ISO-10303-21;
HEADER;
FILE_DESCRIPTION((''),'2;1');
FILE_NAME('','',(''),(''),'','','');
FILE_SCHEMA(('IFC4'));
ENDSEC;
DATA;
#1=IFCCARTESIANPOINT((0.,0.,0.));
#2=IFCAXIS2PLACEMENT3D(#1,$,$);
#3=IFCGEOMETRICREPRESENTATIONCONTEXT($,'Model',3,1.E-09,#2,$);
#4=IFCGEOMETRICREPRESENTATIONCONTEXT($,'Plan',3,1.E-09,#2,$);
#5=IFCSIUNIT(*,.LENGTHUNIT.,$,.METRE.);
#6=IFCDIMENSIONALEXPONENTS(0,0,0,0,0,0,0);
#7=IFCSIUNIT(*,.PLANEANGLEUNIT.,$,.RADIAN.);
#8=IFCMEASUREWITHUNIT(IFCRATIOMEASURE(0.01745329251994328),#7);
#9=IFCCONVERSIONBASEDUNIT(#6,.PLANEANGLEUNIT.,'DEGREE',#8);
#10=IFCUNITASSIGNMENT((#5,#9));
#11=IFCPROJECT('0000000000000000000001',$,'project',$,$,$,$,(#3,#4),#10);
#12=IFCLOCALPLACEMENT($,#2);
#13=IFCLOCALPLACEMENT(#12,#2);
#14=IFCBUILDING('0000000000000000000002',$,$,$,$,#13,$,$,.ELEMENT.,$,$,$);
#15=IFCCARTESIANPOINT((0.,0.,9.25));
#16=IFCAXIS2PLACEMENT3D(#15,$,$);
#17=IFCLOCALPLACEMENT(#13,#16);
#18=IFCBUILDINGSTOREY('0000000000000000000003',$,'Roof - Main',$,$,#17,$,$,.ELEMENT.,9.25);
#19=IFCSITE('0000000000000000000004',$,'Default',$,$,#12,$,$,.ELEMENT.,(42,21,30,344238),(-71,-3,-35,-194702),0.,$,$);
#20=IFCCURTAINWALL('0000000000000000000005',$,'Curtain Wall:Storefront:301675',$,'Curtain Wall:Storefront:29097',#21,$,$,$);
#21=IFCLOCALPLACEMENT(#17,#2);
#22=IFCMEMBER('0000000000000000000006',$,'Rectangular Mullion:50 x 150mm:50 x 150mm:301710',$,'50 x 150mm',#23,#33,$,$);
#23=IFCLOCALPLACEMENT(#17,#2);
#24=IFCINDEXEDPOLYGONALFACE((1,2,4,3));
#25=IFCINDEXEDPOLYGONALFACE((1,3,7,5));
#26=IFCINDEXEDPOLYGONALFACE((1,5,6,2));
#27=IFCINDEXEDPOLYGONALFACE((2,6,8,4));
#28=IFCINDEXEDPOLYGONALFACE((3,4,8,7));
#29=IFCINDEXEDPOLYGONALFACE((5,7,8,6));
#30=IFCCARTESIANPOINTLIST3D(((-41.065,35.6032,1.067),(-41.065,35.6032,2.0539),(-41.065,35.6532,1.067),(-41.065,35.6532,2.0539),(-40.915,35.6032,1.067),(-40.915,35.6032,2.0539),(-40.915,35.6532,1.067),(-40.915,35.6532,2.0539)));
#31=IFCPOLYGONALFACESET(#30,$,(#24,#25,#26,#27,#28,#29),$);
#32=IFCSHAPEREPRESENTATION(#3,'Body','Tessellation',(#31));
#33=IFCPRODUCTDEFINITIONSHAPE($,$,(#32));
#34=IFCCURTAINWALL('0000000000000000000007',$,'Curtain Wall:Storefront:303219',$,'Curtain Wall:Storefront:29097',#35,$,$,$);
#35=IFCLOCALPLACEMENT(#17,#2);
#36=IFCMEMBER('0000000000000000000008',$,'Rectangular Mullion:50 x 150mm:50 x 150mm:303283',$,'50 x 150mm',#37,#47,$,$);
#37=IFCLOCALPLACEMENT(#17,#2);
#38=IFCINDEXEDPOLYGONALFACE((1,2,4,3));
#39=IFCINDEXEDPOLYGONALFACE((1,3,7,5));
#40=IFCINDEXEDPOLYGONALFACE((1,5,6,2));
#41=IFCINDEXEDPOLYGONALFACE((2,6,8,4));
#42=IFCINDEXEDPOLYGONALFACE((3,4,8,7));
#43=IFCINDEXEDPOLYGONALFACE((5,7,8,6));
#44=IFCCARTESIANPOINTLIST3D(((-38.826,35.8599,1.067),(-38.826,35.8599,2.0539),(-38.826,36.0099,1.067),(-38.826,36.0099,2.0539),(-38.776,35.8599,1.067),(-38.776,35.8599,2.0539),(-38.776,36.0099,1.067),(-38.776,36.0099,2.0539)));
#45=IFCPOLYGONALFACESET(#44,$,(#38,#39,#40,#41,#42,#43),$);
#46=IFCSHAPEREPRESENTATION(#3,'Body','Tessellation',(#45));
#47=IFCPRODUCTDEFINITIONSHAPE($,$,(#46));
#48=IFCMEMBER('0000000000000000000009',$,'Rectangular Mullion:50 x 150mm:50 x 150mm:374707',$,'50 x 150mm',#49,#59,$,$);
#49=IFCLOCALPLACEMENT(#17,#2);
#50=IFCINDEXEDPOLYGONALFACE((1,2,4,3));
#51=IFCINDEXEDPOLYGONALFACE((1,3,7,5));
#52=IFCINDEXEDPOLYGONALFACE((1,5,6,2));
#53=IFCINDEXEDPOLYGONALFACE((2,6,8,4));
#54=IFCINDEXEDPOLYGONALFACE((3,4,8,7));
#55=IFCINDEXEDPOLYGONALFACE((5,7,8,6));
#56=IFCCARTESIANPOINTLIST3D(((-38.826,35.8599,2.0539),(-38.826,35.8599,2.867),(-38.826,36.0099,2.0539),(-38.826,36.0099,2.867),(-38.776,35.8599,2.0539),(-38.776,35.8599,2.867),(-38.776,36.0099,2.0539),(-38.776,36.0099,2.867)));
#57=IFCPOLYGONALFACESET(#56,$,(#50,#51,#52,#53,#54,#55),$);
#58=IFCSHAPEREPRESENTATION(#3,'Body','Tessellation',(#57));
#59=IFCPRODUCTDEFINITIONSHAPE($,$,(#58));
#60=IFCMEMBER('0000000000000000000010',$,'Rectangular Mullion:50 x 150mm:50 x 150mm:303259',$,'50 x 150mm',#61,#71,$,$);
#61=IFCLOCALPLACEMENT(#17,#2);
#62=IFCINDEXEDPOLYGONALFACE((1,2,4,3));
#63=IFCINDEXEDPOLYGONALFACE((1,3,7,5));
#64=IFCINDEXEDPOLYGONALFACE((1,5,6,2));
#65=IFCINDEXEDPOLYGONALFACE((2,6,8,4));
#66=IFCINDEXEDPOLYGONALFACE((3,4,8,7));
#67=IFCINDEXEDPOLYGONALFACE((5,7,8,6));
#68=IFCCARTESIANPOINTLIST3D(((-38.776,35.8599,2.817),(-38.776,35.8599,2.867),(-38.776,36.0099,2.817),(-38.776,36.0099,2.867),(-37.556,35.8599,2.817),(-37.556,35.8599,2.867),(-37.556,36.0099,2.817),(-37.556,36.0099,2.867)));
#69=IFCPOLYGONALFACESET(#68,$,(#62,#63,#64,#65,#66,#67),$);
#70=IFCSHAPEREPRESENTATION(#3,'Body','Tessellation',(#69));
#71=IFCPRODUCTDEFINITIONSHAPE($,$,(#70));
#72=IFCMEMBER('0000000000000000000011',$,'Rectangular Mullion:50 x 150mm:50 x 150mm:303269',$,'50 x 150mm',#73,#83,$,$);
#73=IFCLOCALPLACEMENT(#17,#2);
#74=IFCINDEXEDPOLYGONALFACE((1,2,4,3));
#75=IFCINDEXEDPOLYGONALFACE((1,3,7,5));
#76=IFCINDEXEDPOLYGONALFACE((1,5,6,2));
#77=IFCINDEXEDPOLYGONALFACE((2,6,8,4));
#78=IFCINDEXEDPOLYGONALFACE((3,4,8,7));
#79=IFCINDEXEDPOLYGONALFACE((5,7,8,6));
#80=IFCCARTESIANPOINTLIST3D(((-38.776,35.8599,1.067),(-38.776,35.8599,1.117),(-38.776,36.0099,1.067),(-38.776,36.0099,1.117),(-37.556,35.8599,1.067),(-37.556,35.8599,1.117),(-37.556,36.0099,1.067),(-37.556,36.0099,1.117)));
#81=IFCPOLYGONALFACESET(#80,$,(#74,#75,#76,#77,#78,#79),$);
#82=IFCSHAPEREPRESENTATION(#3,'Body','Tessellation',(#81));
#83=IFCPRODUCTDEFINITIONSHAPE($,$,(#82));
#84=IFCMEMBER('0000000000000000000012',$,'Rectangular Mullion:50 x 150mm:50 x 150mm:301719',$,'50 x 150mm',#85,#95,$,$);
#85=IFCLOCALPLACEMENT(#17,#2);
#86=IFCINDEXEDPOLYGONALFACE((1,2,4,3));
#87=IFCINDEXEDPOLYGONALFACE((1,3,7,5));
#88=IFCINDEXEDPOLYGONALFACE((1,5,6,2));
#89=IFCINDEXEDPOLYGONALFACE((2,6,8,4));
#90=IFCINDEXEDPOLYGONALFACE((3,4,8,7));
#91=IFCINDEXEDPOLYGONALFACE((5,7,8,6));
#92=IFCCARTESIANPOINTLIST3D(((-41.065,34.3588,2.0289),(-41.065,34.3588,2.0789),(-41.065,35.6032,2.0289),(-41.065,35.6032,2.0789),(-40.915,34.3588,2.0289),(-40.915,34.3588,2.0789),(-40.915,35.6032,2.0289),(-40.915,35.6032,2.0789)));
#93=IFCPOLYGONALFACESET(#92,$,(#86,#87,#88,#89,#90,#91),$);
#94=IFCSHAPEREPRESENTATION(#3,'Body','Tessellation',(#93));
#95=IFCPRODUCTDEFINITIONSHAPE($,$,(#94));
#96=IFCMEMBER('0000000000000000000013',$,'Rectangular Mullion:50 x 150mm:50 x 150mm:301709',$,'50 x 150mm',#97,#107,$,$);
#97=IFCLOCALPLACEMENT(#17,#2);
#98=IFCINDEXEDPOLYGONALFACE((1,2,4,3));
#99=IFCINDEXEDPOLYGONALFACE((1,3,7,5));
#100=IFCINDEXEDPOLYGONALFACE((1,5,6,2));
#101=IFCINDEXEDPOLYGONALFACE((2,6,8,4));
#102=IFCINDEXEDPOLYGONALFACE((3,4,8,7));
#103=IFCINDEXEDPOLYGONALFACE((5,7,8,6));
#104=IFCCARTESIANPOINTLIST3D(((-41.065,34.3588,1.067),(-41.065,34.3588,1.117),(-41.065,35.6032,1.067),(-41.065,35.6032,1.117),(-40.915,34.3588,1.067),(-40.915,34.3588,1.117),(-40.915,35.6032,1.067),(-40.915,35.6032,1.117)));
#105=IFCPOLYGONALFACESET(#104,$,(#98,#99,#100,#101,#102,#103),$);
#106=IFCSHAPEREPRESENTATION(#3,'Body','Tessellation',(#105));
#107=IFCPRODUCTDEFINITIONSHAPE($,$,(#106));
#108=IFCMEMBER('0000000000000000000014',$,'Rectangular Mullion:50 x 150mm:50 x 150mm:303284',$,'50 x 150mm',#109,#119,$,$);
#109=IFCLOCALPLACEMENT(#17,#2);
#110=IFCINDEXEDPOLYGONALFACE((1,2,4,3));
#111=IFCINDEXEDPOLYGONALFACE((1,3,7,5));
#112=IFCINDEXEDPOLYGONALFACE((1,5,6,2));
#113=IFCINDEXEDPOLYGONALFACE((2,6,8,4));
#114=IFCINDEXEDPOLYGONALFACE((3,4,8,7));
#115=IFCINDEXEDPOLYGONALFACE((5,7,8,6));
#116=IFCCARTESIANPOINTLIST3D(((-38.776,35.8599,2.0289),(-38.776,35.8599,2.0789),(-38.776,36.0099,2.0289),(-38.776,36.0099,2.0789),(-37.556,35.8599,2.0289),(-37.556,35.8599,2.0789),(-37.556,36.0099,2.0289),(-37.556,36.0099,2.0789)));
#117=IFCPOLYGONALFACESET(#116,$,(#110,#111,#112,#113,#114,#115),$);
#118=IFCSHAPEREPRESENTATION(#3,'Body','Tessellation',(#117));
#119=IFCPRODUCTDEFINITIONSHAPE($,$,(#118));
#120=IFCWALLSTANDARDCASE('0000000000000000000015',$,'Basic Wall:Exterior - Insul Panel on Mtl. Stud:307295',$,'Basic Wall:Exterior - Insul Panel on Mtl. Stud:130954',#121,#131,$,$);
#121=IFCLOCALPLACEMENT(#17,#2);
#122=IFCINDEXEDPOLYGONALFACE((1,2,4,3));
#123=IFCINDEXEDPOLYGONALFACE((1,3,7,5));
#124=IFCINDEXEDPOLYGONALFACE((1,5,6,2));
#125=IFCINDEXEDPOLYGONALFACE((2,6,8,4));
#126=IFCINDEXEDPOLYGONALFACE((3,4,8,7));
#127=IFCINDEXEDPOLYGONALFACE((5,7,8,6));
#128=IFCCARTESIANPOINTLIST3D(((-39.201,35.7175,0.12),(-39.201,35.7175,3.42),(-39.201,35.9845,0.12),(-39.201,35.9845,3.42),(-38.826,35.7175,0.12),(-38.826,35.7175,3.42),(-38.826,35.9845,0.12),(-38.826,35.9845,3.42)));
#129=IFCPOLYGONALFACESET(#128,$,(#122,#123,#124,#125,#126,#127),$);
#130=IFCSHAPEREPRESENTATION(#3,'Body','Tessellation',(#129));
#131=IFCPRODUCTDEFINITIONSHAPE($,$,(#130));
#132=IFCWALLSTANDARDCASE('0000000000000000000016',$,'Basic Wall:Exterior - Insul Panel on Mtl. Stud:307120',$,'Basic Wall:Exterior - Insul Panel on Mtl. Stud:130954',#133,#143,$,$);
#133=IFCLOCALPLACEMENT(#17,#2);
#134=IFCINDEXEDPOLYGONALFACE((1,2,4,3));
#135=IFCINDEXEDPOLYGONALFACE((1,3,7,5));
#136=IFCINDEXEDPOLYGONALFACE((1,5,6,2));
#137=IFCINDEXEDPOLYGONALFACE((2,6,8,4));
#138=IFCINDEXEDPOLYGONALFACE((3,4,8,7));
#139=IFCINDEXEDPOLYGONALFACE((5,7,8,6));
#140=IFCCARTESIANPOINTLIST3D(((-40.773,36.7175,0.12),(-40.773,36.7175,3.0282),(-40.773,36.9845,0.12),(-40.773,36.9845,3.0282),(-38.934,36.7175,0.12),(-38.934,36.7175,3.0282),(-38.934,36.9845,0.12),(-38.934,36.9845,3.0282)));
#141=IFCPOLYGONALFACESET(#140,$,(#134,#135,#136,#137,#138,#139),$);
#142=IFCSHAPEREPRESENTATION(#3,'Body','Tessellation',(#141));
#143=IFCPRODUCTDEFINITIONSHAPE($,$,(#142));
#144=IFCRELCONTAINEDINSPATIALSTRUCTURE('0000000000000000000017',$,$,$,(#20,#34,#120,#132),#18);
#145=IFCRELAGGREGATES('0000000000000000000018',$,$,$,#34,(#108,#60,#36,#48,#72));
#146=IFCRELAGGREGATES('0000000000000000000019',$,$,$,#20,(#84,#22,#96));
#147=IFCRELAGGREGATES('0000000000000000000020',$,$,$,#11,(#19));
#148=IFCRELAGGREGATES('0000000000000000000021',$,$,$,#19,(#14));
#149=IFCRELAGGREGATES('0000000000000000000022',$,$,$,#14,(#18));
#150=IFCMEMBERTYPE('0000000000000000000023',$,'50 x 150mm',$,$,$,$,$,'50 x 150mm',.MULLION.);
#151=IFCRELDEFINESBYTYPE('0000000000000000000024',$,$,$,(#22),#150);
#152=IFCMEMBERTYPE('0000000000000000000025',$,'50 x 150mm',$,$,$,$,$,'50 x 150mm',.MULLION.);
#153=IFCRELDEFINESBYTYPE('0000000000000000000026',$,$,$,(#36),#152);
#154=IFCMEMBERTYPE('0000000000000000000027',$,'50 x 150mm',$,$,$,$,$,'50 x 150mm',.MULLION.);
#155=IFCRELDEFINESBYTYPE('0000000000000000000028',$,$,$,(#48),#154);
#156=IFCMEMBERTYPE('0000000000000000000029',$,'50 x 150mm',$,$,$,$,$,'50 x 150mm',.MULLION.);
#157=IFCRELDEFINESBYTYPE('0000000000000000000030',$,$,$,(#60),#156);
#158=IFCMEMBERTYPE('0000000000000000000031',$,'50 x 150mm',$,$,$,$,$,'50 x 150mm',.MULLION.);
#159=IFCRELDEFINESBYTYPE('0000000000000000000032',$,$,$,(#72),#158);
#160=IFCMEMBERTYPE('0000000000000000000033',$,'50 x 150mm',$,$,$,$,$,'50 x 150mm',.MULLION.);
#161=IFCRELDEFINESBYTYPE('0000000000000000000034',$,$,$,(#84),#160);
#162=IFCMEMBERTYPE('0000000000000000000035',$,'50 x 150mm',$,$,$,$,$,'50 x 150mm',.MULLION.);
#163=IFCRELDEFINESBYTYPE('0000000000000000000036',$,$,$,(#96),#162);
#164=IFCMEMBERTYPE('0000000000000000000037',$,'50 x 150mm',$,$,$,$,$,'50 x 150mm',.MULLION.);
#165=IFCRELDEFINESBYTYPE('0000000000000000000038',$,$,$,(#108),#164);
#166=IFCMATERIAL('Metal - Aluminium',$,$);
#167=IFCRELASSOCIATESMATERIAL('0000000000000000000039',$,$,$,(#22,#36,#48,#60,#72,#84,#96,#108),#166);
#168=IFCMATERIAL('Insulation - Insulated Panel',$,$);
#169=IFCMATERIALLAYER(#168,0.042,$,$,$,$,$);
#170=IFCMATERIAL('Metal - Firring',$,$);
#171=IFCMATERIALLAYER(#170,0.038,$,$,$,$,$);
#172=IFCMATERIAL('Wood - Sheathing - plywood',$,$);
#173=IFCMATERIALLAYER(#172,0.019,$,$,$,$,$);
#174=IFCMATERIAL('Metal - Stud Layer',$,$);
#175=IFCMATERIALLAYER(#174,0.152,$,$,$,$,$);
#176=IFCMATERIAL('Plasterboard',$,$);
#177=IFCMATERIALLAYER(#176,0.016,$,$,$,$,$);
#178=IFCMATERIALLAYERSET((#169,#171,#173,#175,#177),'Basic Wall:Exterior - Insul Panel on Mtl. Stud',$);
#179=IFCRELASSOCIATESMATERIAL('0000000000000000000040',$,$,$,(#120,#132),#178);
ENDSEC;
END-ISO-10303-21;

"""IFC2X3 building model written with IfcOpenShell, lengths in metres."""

from ifc_helpers import new_model, entity, si_unit, converted_unit, frame, frame_2d, origin, origin_2d_with_axis, place, context, project, spatial, rectangle, extrude, source, transform, mapped, material, layer, layer_set, layer_usage, type_object, type_shapes, element, aggregate, save


model = new_model("IFC2X3")

# Units and contexts
model_context = context("Model", 3, precision=1e-09, world=origin())
plan_context = context("Plan", 3, precision=1e-09, world=origin())
ifc_project = project(units=[si_unit("LENGTHUNIT", "METRE"), converted_unit("PLANEANGLEUNIT", "DEGREE", entity("IfcRatioMeasure", 0.01745329251994328), si_unit("PLANEANGLEUNIT", "RADIAN"), dimensions=[0, 0, 0, 0, 0, 0, 0])], contexts=[model_context, plan_context])

# Site, building, storey
site_placement = place(None, origin())
site = spatial("IfcSite", under=ifc_project, at=site_placement, Name="Default", CompositionType="ELEMENT", RefLatitude=(42, 21, 30, 344238), RefLongitude=(-71, -3, -35, -194702), RefElevation=0.0)
building_placement = place(site_placement, origin())
building = spatial("IfcBuilding", under=site, at=building_placement, CompositionType="ELEMENT")
storey_placement = place(building_placement, frame((0.0, 0.0, 9.25)))
storey = spatial("IfcBuildingStorey", under=building, at=storey_placement, Name="Roof - Main", CompositionType="ELEMENT", Elevation=9.25)

# Curtain wall, member
curtain_wall_1_placement = place(storey_placement, origin())
curtain_wall_1 = element("IfcCurtainWall", 1, at=curtain_wall_1_placement, inside=storey, Name="Curtain Wall:Storefront:301675", ObjectType="Curtain Wall:Storefront:29097")
ifc_material_1 = material(Name="Metal - Aluminium")
member_type_1 = type_object("IfcMemberType", Name="50 x 150mm", ElementType="50 x 150mm", PredefinedType="MULLION")
shared_shape_1 = source(origin(), model_context, "Body", "SweptSolid", [
    extrude(rectangle(XDim=0.05, YDim=0.15, at=origin_2d_with_axis()), frame((-0.025, 0.0, -0.9869), z_axis=(0.0, 0.0, 1.0), x_axis=(-1.0, 0.0, 0.0)), (0.0, 0.0, 1.0), 0.9869),
])
type_shapes(member_type_1, [shared_shape_1])
member_1_placement = place(storey_placement, frame((-40.99, 35.6532, 1.067), z_axis=(0.0, 0.0, -1.0), x_axis=(0.0, 1.0, 0.0)))
member_1 = element("IfcMember", 2, at=member_1_placement, type_object=member_type_1, material=ifc_material_1, Name="Rectangular Mullion:50 x 150mm:50 x 150mm:301710", ObjectType="50 x 150mm", context=model_context, shape_type="MappedRepresentation", body=[
    mapped(shared_shape_1, transform((0.0, 0.0, 0.0), scale=1.0)),
])

# Curtain wall, members
curtain_wall_2_placement = place(storey_placement, origin())
curtain_wall_2 = element("IfcCurtainWall", 3, at=curtain_wall_2_placement, inside=storey, Name="Curtain Wall:Storefront:303219", ObjectType="Curtain Wall:Storefront:29097")
member_type_2 = type_object("IfcMemberType", Name="50 x 150mm", ElementType="50 x 150mm", PredefinedType="MULLION")
shared_shape_2 = source(origin(), model_context, "Body", "SweptSolid", [
    extrude(rectangle(XDim=0.05, YDim=0.15, at=origin_2d_with_axis()), frame((-0.025, 0.0, -0.9869), z_axis=(0.0, 0.0, 1.0), x_axis=(-1.0, 0.0, 0.0)), (0.0, 0.0, 1.0), 0.9869),
])
type_shapes(member_type_2, [shared_shape_2])
member_2_placement = place(storey_placement, frame((-38.826, 35.9349, 2.0539), z_axis=(0.0, 0.0, 1.0), x_axis=(-1.0, 0.0, 0.0)))
member_2 = element("IfcMember", 4, at=member_2_placement, type_object=member_type_2, material=ifc_material_1, Name="Rectangular Mullion:50 x 150mm:50 x 150mm:303283", ObjectType="50 x 150mm", context=model_context, shape_type="MappedRepresentation", body=[
    mapped(shared_shape_2, transform((0.0, 0.0, 0.0), scale=1.0)),
])
member_type_3 = type_object("IfcMemberType", Name="50 x 150mm", ElementType="50 x 150mm", PredefinedType="MULLION")
shared_shape_3 = source(origin(), model_context, "Body", "SweptSolid", [
    extrude(rectangle(XDim=0.05, YDim=0.15, at=origin_2d_with_axis()), frame((-0.025, 0.0, -0.8131), z_axis=(0.0, 0.0, 1.0), x_axis=(-1.0, 0.0, 0.0)), (0.0, 0.0, 1.0), 0.8131),
])
type_shapes(member_type_3, [shared_shape_3])
member_3_placement = place(storey_placement, frame((-38.826, 35.9349, 2.867), z_axis=(0.0, 0.0, 1.0), x_axis=(-1.0, 0.0, 0.0)))
member_3 = element("IfcMember", 5, at=member_3_placement, type_object=member_type_3, material=ifc_material_1, Name="Rectangular Mullion:50 x 150mm:50 x 150mm:374707", ObjectType="50 x 150mm", context=model_context, shape_type="MappedRepresentation", body=[
    mapped(shared_shape_3, transform((0.0, 0.0, 0.0), scale=1.0)),
])
member_type_4 = type_object("IfcMemberType", Name="50 x 150mm", ElementType="50 x 150mm", PredefinedType="MULLION")
shared_shape_4 = source(origin(), model_context, "Body", "SweptSolid", [
    extrude(rectangle(XDim=0.05, YDim=0.15, at=origin_2d_with_axis()), frame((-0.025, 0.0, -1.22), z_axis=(0.0, 0.0, 1.0), x_axis=(-1.0, 0.0, 0.0)), (0.0, 0.0, 1.0), 1.22),
])
type_shapes(member_type_4, [shared_shape_4])
member_4_placement = place(storey_placement, frame((-37.556, 35.9349, 2.867), z_axis=(1.0, 0.0, 0.0), x_axis=(0.0, 0.0, 1.0)))
member_4 = element("IfcMember", 6, at=member_4_placement, type_object=member_type_4, material=ifc_material_1, Name="Rectangular Mullion:50 x 150mm:50 x 150mm:303259", ObjectType="50 x 150mm", context=model_context, shape_type="MappedRepresentation", body=[
    mapped(shared_shape_4, transform((0.0, 0.0, 0.0), scale=1.0)),
])
member_type_5 = type_object("IfcMemberType", Name="50 x 150mm", ElementType="50 x 150mm", PredefinedType="MULLION")
type_shapes(member_type_5, [shared_shape_4])
member_5_placement = place(storey_placement, frame((-38.776, 35.9349, 1.067), z_axis=(-1.0, 0.0, 0.0), x_axis=(0.0, 0.0, -1.0)))
member_5 = element("IfcMember", 7, at=member_5_placement, type_object=member_type_5, material=ifc_material_1, Name="Rectangular Mullion:50 x 150mm:50 x 150mm:303269", ObjectType="50 x 150mm", context=model_context, shape_type="MappedRepresentation", body=[
    mapped(shared_shape_4, transform((0.0, 0.0, 0.0), scale=1.0)),
])

# Members
member_type_6 = type_object("IfcMemberType", Name="50 x 150mm", ElementType="50 x 150mm", PredefinedType="MULLION")
shared_shape_5 = source(origin(), model_context, "Body", "SweptSolid", [
    extrude(rectangle(XDim=0.05, YDim=0.15, at=origin_2d_with_axis()), frame((0.0, 0.0, -1.2444), z_axis=(0.0, 0.0, 1.0), x_axis=(-1.0, 0.0, 0.0)), (0.0, 0.0, 1.0), 1.2444),
])
type_shapes(member_type_6, [shared_shape_5])
member_6_placement = place(storey_placement, frame((-40.99, 35.6032, 2.0539), z_axis=(0.0, 1.0, 0.0), x_axis=(0.0, 0.0, 1.0)))
member_6 = element("IfcMember", 8, at=member_6_placement, type_object=member_type_6, material=ifc_material_1, Name="Rectangular Mullion:50 x 150mm:50 x 150mm:301719", ObjectType="50 x 150mm", context=model_context, shape_type="MappedRepresentation", body=[
    mapped(shared_shape_5, transform((0.0, 0.0, 0.0), scale=1.0)),
])
member_type_7 = type_object("IfcMemberType", Name="50 x 150mm", ElementType="50 x 150mm", PredefinedType="MULLION")
shared_shape_6 = source(origin(), model_context, "Body", "SweptSolid", [
    extrude(rectangle(XDim=0.05, YDim=0.15, at=origin_2d_with_axis()), frame((-0.025, 0.0, -1.2444), z_axis=(0.0, 0.0, 1.0), x_axis=(-1.0, 0.0, 0.0)), (0.0, 0.0, 1.0), 1.2444),
])
type_shapes(member_type_7, [shared_shape_6])
member_7_placement = place(storey_placement, frame((-40.99, 34.3588, 1.067), z_axis=(0.0, -1.0, 0.0), x_axis=(0.0, 0.0, -1.0)))
member_7 = element("IfcMember", 9, at=member_7_placement, type_object=member_type_7, material=ifc_material_1, Name="Rectangular Mullion:50 x 150mm:50 x 150mm:301709", ObjectType="50 x 150mm", context=model_context, shape_type="MappedRepresentation", body=[
    mapped(shared_shape_6, transform((0.0, 0.0, 0.0), scale=1.0)),
])
member_type_8 = type_object("IfcMemberType", Name="50 x 150mm", ElementType="50 x 150mm", PredefinedType="MULLION")
shared_shape_7 = source(origin(), model_context, "Body", "SweptSolid", [
    extrude(rectangle(XDim=0.05, YDim=0.15, at=origin_2d_with_axis()), frame((0.0, 0.0, -1.22), z_axis=(0.0, 0.0, 1.0), x_axis=(-1.0, 0.0, 0.0)), (0.0, 0.0, 1.0), 1.22),
])
type_shapes(member_type_8, [shared_shape_7])
member_8_placement = place(storey_placement, frame((-37.556, 35.9349, 2.0539), z_axis=(1.0, 0.0, 0.0), x_axis=(0.0, 0.0, 1.0)))
member_8 = element("IfcMember", 10, at=member_8_placement, type_object=member_type_8, material=ifc_material_1, Name="Rectangular Mullion:50 x 150mm:50 x 150mm:303284", ObjectType="50 x 150mm", context=model_context, shape_type="MappedRepresentation", body=[
    mapped(shared_shape_7, transform((0.0, 0.0, 0.0), scale=1.0)),
])

aggregate(curtain_wall_2, [member_8, member_4, member_2, member_3, member_5])
aggregate(curtain_wall_1, [member_6, member_1, member_7])

# Shared definitions
ifc_material_2 = material(Name="Insulation - Insulated Panel")
ifc_layer_1 = layer(ifc_material_2, 0.042)
ifc_material_3 = material(Name="Metal - Firring")
ifc_layer_2 = layer(ifc_material_3, 0.038)
ifc_material_4 = material(Name="Wood - Sheathing - plywood")
ifc_layer_3 = layer(ifc_material_4, 0.019)
ifc_material_5 = material(Name="Metal - Stud Layer")
ifc_layer_4 = layer(ifc_material_5, 0.152)
ifc_material_6 = material(Name="Plasterboard")
ifc_layer_5 = layer(ifc_material_6, 0.016)
ifc_layer_set = layer_set([ifc_layer_1, ifc_layer_2, ifc_layer_3, ifc_layer_4, ifc_layer_5], Name="Basic Wall:Exterior - Insul Panel on Mtl. Stud")
ifc_layer_usage = layer_usage(ifc_layer_set, "AXIS2", "NEGATIVE", 0.1335)

# Walls
wall_1_placement = place(storey_placement, frame((-39.201, 35.851, 0.12)))
element("IfcWallStandardCase", 11, at=wall_1_placement, inside=storey, material=ifc_layer_usage, Name="Basic Wall:Exterior - Insul Panel on Mtl. Stud:307295", ObjectType="Basic Wall:Exterior - Insul Panel on Mtl. Stud:130954", context=model_context, shape_type="SweptSolid", body=[
    extrude(rectangle(XDim=0.375, YDim=0.267, at=frame_2d((0.1875, 0.0), x_axis=(-1.0, 0.0))), origin(), (0.0, 0.0, 1.0), 3.3),
])
wall_2_placement = place(storey_placement, frame((-40.773, 36.851, 0.12)))
element("IfcWallStandardCase", 12, at=wall_2_placement, inside=storey, material=ifc_layer_usage, Name="Basic Wall:Exterior - Insul Panel on Mtl. Stud:307120", ObjectType="Basic Wall:Exterior - Insul Panel on Mtl. Stud:130954", context=model_context, shape_type="SweptSolid", body=[
    extrude(rectangle(XDim=1.839, YDim=0.267, at=frame_2d((0.9195, 0.0), x_axis=(-1.0, 0.0))), origin(), (0.0, 0.0, 1.0), 2.9082),
])

save(model, "model.ifc")
